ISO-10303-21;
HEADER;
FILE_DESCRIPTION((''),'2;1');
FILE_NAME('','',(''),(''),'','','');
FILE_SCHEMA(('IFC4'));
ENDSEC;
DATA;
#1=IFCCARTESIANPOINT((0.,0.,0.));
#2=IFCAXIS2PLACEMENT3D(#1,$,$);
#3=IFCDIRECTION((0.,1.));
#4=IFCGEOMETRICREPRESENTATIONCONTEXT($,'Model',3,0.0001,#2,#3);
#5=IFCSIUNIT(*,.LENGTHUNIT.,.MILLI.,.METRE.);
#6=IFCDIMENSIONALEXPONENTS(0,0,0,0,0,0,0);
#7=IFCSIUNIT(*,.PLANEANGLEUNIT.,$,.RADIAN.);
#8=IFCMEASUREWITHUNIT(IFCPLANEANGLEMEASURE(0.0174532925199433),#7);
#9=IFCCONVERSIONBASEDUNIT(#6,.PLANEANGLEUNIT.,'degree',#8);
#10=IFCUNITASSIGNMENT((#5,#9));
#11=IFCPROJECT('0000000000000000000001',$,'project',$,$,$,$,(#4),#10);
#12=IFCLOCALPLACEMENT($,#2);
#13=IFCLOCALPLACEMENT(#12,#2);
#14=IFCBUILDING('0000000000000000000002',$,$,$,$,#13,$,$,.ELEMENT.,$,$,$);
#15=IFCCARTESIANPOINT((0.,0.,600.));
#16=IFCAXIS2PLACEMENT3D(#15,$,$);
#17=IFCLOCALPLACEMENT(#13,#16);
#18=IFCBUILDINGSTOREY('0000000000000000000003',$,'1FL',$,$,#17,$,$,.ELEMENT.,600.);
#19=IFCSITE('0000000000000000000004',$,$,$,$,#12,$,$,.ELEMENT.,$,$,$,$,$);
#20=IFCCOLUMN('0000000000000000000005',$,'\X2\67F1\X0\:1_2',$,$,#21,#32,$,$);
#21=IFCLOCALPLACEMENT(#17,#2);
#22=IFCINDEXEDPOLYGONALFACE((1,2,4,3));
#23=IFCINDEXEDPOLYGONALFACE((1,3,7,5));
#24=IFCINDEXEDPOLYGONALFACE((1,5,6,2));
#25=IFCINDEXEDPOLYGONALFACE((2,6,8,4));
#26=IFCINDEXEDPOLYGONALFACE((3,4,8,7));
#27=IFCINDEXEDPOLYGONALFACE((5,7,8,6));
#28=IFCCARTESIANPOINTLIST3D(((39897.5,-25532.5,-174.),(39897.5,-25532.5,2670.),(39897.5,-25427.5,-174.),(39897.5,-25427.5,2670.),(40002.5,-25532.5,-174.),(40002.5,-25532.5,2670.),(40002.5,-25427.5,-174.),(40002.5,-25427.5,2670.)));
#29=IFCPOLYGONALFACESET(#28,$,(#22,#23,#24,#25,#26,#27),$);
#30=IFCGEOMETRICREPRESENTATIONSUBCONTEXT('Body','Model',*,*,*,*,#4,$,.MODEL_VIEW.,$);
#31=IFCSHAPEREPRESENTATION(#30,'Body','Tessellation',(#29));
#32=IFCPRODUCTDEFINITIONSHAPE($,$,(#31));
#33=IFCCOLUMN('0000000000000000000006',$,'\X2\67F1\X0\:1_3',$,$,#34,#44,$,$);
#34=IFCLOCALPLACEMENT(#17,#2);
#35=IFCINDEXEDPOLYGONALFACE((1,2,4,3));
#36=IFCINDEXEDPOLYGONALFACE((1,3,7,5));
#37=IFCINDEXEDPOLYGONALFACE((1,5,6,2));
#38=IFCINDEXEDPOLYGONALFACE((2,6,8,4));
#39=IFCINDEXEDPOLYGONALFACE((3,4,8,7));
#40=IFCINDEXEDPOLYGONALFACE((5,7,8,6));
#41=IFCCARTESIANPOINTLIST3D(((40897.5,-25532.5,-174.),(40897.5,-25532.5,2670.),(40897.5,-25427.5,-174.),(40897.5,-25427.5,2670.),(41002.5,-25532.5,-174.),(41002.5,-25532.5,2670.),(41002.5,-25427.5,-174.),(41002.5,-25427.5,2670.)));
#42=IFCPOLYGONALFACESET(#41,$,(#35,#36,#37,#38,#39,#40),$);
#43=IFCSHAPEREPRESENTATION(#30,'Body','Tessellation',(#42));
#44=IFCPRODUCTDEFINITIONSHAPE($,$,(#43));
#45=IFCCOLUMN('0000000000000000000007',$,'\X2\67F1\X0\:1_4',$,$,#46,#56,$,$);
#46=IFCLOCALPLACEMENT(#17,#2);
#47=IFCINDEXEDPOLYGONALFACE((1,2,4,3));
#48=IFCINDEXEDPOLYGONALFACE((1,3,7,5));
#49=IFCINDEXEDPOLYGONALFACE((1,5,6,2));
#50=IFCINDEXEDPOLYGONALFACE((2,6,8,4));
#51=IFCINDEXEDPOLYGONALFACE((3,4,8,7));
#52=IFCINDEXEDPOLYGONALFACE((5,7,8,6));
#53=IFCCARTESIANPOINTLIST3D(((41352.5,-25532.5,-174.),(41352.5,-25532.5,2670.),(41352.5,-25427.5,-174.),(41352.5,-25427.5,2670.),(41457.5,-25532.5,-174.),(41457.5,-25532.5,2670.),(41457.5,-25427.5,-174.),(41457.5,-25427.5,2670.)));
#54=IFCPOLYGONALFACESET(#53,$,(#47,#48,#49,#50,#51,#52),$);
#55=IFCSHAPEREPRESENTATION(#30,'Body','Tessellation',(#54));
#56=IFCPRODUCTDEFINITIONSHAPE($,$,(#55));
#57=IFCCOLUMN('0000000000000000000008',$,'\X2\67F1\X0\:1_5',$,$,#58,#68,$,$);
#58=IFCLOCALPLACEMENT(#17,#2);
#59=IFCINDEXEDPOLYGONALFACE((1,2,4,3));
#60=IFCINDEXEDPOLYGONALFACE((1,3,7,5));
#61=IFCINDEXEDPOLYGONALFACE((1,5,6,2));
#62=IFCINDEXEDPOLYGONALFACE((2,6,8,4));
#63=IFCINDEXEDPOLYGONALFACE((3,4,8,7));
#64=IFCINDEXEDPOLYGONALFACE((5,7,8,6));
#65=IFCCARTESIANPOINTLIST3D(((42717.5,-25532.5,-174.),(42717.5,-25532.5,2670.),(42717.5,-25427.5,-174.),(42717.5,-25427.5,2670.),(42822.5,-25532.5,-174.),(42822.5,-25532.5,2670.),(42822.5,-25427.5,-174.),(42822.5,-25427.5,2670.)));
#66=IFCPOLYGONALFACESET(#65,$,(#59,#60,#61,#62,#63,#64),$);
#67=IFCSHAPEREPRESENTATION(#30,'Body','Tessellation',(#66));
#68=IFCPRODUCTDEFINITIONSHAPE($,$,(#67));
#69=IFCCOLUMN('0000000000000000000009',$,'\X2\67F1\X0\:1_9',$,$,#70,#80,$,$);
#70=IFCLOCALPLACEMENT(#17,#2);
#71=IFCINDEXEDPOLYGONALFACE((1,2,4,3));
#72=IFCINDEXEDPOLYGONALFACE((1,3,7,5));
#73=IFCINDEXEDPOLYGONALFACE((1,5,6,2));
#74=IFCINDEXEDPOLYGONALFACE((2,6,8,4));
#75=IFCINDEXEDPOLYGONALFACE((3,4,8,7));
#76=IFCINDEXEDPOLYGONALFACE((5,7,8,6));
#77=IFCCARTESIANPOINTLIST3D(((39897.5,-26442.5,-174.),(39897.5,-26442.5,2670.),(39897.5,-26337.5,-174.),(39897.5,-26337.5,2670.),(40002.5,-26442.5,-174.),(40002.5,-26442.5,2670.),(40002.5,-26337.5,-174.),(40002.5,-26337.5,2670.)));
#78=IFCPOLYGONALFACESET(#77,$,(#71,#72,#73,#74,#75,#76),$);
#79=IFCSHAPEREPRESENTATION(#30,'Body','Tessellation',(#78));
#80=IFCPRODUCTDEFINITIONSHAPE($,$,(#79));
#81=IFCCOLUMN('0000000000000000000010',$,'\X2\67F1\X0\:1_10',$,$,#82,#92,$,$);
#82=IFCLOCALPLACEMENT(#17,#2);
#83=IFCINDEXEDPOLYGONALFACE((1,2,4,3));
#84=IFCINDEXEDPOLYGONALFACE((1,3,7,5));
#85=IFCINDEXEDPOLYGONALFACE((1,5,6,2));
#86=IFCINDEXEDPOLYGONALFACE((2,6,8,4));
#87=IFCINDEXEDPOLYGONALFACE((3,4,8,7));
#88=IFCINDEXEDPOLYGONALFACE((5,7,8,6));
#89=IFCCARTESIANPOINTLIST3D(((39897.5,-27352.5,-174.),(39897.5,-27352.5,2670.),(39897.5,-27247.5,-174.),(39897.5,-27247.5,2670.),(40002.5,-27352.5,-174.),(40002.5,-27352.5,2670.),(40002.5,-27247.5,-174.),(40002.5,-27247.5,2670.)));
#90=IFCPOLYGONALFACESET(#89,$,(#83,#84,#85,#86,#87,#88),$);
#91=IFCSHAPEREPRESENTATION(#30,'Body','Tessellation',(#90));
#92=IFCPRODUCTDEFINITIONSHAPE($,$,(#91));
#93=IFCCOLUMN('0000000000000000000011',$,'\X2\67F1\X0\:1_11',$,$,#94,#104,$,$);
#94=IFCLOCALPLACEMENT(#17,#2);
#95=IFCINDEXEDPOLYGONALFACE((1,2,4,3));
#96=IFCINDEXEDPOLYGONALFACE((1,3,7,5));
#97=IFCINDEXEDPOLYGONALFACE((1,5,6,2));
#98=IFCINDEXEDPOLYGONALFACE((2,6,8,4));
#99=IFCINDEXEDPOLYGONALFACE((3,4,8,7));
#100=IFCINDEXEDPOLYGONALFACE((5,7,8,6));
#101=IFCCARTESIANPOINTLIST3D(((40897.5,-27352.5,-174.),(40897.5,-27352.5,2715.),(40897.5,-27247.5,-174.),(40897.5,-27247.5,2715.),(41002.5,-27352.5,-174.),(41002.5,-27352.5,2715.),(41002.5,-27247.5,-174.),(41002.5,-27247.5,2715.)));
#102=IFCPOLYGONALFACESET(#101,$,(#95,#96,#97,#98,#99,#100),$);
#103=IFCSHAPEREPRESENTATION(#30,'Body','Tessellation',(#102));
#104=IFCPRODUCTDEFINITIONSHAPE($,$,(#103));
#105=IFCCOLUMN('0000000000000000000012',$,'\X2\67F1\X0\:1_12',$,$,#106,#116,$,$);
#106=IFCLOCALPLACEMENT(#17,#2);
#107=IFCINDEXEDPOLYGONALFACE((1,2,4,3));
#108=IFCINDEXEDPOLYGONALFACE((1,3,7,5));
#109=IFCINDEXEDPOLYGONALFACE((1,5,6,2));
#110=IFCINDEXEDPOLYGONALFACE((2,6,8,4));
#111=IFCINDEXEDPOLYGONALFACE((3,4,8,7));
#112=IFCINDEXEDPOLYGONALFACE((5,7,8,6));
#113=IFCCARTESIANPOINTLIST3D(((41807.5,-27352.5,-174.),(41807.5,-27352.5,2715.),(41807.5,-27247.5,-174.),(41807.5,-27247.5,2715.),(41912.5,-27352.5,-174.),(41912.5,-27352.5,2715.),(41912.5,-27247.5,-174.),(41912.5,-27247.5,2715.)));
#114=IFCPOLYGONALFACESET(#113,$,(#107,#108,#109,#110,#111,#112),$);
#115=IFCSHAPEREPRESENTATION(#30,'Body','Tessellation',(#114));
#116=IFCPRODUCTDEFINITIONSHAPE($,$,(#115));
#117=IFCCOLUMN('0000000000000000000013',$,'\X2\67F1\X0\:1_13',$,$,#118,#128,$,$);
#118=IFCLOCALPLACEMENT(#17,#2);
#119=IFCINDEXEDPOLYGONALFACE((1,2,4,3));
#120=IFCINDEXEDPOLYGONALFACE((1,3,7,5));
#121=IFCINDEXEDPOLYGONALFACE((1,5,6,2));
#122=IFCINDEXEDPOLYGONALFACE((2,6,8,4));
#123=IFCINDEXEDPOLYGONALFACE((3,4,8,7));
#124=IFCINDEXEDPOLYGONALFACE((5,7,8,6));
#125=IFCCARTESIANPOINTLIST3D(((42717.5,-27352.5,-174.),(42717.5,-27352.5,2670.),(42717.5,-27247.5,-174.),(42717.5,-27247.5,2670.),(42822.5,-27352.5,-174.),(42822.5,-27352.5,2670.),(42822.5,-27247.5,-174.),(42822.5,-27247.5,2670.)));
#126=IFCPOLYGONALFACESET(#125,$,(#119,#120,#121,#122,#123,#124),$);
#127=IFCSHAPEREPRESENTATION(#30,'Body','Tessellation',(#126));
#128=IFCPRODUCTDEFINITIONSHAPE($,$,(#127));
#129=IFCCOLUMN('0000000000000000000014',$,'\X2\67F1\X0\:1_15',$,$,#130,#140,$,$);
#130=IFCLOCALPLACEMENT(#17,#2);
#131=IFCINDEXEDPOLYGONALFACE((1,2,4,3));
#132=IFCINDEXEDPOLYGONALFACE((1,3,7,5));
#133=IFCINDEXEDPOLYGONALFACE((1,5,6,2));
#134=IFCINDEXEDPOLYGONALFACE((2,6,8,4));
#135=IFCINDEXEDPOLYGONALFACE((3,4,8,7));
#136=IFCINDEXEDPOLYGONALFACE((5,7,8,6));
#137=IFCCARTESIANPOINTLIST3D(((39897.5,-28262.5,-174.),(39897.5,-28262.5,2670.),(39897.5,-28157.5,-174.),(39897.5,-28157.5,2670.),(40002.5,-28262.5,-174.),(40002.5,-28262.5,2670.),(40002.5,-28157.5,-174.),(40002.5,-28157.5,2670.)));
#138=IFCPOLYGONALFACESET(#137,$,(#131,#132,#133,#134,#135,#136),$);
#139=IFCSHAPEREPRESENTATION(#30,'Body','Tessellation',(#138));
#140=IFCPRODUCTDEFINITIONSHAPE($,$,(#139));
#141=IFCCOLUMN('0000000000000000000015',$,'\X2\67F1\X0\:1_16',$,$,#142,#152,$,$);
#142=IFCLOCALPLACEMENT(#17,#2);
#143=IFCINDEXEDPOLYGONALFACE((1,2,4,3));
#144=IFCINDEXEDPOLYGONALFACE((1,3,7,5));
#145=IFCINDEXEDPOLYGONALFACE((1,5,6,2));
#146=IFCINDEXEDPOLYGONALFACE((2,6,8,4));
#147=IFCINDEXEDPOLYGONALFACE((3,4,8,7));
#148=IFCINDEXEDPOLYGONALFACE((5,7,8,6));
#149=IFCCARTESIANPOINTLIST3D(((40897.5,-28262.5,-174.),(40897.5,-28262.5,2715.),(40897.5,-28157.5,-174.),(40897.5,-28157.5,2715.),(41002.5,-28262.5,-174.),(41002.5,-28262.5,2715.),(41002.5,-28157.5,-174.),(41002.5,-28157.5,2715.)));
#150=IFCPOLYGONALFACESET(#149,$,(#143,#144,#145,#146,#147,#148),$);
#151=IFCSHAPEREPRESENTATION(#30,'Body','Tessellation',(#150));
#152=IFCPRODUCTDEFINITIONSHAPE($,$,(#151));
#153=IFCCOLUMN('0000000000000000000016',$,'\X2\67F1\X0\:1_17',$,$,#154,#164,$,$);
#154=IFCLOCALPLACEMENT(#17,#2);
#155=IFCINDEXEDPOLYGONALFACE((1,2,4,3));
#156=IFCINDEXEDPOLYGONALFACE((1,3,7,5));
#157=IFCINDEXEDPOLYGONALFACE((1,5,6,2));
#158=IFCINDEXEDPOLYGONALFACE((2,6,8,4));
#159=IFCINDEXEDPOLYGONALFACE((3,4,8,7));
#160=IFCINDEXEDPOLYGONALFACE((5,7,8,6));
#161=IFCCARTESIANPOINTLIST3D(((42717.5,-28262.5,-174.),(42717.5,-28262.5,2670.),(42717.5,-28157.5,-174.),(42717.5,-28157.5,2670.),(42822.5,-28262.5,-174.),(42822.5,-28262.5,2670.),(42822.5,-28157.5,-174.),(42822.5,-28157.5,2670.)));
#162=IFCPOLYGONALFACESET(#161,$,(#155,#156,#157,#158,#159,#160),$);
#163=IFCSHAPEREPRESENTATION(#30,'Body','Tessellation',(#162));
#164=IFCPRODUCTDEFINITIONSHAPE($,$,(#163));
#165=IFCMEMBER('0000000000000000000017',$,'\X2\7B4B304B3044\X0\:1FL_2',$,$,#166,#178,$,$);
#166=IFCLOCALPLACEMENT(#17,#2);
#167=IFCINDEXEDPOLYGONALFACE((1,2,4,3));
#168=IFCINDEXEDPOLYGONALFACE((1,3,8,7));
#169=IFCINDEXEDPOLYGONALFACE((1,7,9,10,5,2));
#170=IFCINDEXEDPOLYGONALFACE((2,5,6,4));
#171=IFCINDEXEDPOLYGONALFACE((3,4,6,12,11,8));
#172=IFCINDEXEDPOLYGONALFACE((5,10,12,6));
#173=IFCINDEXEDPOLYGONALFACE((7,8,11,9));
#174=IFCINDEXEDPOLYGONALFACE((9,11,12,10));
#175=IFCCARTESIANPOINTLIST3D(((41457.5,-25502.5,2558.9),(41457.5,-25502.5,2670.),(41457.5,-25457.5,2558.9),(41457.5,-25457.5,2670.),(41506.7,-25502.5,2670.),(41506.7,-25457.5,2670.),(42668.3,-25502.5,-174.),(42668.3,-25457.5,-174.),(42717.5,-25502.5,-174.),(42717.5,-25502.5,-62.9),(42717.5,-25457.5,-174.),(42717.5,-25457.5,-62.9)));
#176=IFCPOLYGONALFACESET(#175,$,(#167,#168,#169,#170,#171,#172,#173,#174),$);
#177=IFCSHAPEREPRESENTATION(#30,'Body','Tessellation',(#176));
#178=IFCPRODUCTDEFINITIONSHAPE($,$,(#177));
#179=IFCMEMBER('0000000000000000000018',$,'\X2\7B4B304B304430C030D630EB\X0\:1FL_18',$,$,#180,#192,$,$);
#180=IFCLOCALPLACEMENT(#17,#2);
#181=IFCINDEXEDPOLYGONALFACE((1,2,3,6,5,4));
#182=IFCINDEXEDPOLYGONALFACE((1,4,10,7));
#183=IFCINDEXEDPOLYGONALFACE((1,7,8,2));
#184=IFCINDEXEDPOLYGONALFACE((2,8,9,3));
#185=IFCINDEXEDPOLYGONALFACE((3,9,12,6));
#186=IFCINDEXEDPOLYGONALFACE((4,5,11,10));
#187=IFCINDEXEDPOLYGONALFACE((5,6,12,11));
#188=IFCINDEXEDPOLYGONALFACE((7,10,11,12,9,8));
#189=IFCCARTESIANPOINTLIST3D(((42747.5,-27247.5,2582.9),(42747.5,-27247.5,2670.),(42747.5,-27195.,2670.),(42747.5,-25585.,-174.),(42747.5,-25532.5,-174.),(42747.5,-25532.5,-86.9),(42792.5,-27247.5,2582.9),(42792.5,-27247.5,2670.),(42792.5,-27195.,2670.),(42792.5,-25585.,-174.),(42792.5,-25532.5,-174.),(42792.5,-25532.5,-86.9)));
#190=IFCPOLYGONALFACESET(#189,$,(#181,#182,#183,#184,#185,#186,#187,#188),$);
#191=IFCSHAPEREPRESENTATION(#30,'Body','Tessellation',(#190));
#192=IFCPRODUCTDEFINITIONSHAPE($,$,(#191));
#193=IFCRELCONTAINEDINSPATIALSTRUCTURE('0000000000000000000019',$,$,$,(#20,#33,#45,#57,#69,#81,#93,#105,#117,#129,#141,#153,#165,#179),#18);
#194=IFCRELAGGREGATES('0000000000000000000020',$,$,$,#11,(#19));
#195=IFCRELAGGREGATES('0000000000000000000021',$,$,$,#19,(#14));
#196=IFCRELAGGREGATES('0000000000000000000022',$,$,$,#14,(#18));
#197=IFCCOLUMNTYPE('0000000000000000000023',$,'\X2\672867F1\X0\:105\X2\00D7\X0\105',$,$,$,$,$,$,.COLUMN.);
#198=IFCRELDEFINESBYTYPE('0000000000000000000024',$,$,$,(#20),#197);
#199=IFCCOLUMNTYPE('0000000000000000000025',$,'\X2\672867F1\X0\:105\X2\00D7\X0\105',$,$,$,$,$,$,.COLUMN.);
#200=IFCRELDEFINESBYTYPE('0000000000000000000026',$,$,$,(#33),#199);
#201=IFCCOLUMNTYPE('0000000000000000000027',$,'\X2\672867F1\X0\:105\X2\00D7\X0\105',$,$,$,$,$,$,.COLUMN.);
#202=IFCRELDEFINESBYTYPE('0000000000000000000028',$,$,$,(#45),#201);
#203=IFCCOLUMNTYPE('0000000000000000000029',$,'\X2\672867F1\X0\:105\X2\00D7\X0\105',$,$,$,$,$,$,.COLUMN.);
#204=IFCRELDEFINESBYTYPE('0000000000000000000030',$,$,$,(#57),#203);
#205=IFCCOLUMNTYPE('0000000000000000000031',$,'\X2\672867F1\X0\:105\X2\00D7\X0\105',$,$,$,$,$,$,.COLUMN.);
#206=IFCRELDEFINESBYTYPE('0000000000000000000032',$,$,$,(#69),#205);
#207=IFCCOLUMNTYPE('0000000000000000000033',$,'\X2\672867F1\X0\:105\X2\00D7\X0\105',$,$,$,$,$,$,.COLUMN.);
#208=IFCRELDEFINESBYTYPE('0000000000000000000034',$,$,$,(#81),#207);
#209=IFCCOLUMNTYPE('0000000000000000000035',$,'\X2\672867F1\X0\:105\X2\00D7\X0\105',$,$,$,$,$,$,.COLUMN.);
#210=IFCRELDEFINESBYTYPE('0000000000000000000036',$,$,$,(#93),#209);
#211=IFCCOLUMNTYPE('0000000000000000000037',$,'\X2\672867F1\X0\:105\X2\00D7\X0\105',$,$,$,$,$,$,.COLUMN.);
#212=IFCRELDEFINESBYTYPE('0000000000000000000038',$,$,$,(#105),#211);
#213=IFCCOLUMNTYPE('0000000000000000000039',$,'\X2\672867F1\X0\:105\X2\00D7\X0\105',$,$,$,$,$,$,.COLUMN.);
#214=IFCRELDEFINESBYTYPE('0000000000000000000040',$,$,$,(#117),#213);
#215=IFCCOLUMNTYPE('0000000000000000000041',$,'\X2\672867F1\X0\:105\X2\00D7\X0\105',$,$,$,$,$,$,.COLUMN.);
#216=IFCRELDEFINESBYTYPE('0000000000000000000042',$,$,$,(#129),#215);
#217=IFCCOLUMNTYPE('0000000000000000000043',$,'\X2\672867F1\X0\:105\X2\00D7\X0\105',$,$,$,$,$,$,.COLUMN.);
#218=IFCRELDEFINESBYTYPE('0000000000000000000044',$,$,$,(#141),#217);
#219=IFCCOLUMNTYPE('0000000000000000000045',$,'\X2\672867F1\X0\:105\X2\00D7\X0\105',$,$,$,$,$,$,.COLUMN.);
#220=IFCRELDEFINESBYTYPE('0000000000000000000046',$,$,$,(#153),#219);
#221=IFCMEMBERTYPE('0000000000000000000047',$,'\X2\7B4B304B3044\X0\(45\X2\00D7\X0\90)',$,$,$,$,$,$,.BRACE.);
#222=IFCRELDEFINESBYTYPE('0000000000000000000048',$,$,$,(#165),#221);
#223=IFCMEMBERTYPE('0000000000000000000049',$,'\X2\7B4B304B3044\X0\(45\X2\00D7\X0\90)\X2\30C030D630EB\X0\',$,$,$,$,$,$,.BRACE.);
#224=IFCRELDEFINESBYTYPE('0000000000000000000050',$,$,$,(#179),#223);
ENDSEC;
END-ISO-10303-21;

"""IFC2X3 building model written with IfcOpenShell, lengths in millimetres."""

from ifc_helpers import new_model, entity, si_unit, converted_unit, direction, frame, origin, origin_with_axes, origin_2d, place, context, subcontext, project, spatial, polyline, rectangle, outline, extrude, type_object, element, save


model = new_model("IFC2X3")

# Units and contexts
model_context = context("Model", 3, precision=0.0001, world=origin(), true_north=direction((0.0, 1.0)))
body_context = subcontext(model_context, "Body", "Model", "MODEL_VIEW")
ifc_project = project(units=[si_unit("LENGTHUNIT", "METRE", prefix="MILLI"), converted_unit("PLANEANGLEUNIT", "degree", entity("IfcPlaneAngleMeasure", 0.0174532925199433), si_unit("PLANEANGLEUNIT", "RADIAN"), dimensions=[0, 0, 0, 0, 0, 0, 0])], contexts=[model_context])

# Site, building, storey
site_placement = place(None, origin())
site = spatial("IfcSite", under=ifc_project, at=site_placement, CompositionType="ELEMENT")
building_placement = place(site_placement, origin())
building = spatial("IfcBuilding", under=site, at=building_placement, CompositionType="ELEMENT")
storey_placement = place(building_placement, frame((0.0, 0.0, 600.0)))
storey = spatial("IfcBuildingStorey", under=building, at=storey_placement, Name="1FL", CompositionType="ELEMENT", Elevation=600.0)

# Columns
column_type_1 = type_object("IfcColumnType", Name="木柱:105×105", PredefinedType="COLUMN")
column_1_placement = place(storey_placement, frame((39950.0, -25480.0, -174.0)))
element("IfcColumn", 1, at=column_1_placement, inside=storey, type_object=column_type_1, Name="柱:1_2", context=body_context, shape_type="SweptSolid", body=[
    extrude(rectangle(XDim=105.0, YDim=105.0, at=origin_2d()), origin_with_axes(), (0.0, 0.0, 1.0), 2844.0),
])
column_type_2 = type_object("IfcColumnType", Name="木柱:105×105", PredefinedType="COLUMN")
column_2_placement = place(storey_placement, frame((40950.0, -25480.0, -174.0)))
element("IfcColumn", 2, at=column_2_placement, inside=storey, type_object=column_type_2, Name="柱:1_3", context=body_context, shape_type="SweptSolid", body=[
    extrude(rectangle(XDim=105.0, YDim=105.0, at=origin_2d()), origin_with_axes(), (0.0, 0.0, 1.0), 2844.0),
])
column_type_3 = type_object("IfcColumnType", Name="木柱:105×105", PredefinedType="COLUMN")
column_3_placement = place(storey_placement, frame((41405.0, -25480.0, -174.0)))
element("IfcColumn", 3, at=column_3_placement, inside=storey, type_object=column_type_3, Name="柱:1_4", context=body_context, shape_type="SweptSolid", body=[
    extrude(rectangle(XDim=105.0, YDim=105.0, at=origin_2d()), origin_with_axes(), (0.0, 0.0, 1.0), 2844.0),
])
column_type_4 = type_object("IfcColumnType", Name="木柱:105×105", PredefinedType="COLUMN")
column_4_placement = place(storey_placement, frame((42770.0, -25480.0, -174.0)))
element("IfcColumn", 4, at=column_4_placement, inside=storey, type_object=column_type_4, Name="柱:1_5", context=body_context, shape_type="SweptSolid", body=[
    extrude(rectangle(XDim=105.0, YDim=105.0, at=origin_2d()), origin_with_axes(), (0.0, 0.0, 1.0), 2844.0),
])
column_type_5 = type_object("IfcColumnType", Name="木柱:105×105", PredefinedType="COLUMN")
column_5_placement = place(storey_placement, frame((39950.0, -26390.0, -174.0)))
element("IfcColumn", 5, at=column_5_placement, inside=storey, type_object=column_type_5, Name="柱:1_9", context=body_context, shape_type="SweptSolid", body=[
    extrude(rectangle(XDim=105.0, YDim=105.0, at=origin_2d()), origin_with_axes(), (0.0, 0.0, 1.0), 2844.0),
])
column_type_6 = type_object("IfcColumnType", Name="木柱:105×105", PredefinedType="COLUMN")
column_6_placement = place(storey_placement, frame((39950.0, -27300.0, -174.0)))
element("IfcColumn", 6, at=column_6_placement, inside=storey, type_object=column_type_6, Name="柱:1_10", context=body_context, shape_type="SweptSolid", body=[
    extrude(rectangle(XDim=105.0, YDim=105.0, at=origin_2d()), origin_with_axes(), (0.0, 0.0, 1.0), 2844.0),
])
column_type_7 = type_object("IfcColumnType", Name="木柱:105×105", PredefinedType="COLUMN")
column_7_placement = place(storey_placement, frame((40950.0, -27300.0, -174.0)))
element("IfcColumn", 7, at=column_7_placement, inside=storey, type_object=column_type_7, Name="柱:1_11", context=body_context, shape_type="SweptSolid", body=[
    extrude(rectangle(XDim=105.0, YDim=105.0, at=origin_2d()), origin_with_axes(), (0.0, 0.0, 1.0), 2889.0),
])
column_type_8 = type_object("IfcColumnType", Name="木柱:105×105", PredefinedType="COLUMN")
column_8_placement = place(storey_placement, frame((41860.0, -27300.0, -174.0)))
element("IfcColumn", 8, at=column_8_placement, inside=storey, type_object=column_type_8, Name="柱:1_12", context=body_context, shape_type="SweptSolid", body=[
    extrude(rectangle(XDim=105.0, YDim=105.0, at=origin_2d()), origin_with_axes(), (0.0, 0.0, 1.0), 2889.0),
])
column_type_9 = type_object("IfcColumnType", Name="木柱:105×105", PredefinedType="COLUMN")
column_9_placement = place(storey_placement, frame((42770.0, -27300.0, -174.0)))
element("IfcColumn", 9, at=column_9_placement, inside=storey, type_object=column_type_9, Name="柱:1_13", context=body_context, shape_type="SweptSolid", body=[
    extrude(rectangle(XDim=105.0, YDim=105.0, at=origin_2d()), origin_with_axes(), (0.0, 0.0, 1.0), 2844.0),
])
column_type_10 = type_object("IfcColumnType", Name="木柱:105×105", PredefinedType="COLUMN")
column_10_placement = place(storey_placement, frame((39950.0, -28210.0, -174.0)))
element("IfcColumn", 10, at=column_10_placement, inside=storey, type_object=column_type_10, Name="柱:1_15", context=body_context, shape_type="SweptSolid", body=[
    extrude(rectangle(XDim=105.0, YDim=105.0, at=origin_2d()), origin_with_axes(), (0.0, 0.0, 1.0), 2844.0),
])
column_type_11 = type_object("IfcColumnType", Name="木柱:105×105", PredefinedType="COLUMN")
column_11_placement = place(storey_placement, frame((40950.0, -28210.0, -174.0)))
element("IfcColumn", 11, at=column_11_placement, inside=storey, type_object=column_type_11, Name="柱:1_16", context=body_context, shape_type="SweptSolid", body=[
    extrude(rectangle(XDim=105.0, YDim=105.0, at=origin_2d()), origin_with_axes(), (0.0, 0.0, 1.0), 2889.0),
])
column_type_12 = type_object("IfcColumnType", Name="木柱:105×105", PredefinedType="COLUMN")
column_12_placement = place(storey_placement, frame((42770.0, -28210.0, -174.0)))
element("IfcColumn", 12, at=column_12_placement, inside=storey, type_object=column_type_12, Name="柱:1_17", context=body_context, shape_type="SweptSolid", body=[
    extrude(rectangle(XDim=105.0, YDim=105.0, at=origin_2d()), origin_with_axes(), (0.0, 0.0, 1.0), 2844.0),
])

# Members
member_type_1 = type_object("IfcMemberType", Name="筋かい(45×90)", PredefinedType="BRACE")
member_1_placement = place(storey_placement, frame((42717.5, -25480.0, -174.0), z_axis=(-0.405064, 0.0, 0.914288), x_axis=(0.914288, 0.0, 0.405064)))
element("IfcMember", 13, at=member_1_placement, inside=storey, type_object=member_type_1, Name="筋かい:1FL_2", context=body_context, shape_type="SweptSolid", body=[
    extrude(outline(polyline([(0.0, 0.0), (19.9, -45.0), (3009.0, -45.0), (3110.6, 0.0), (3090.7, 45.0), (101.6, 45.0), (0.0, 0.0)])), frame((0.0, -22.5, 0.0), z_axis=(0.0, 1.0, 0.0), x_axis=(0.0, 0.0, 1.0)), (0.0, 0.0, 1.0), 45.0),
])
member_type_2 = type_object("IfcMemberType", Name="筋かい(45×90)ダブル", PredefinedType="BRACE")
member_2_placement = place(storey_placement, frame((42770.0, -25532.5, -174.0), z_axis=(0.0, -0.516399, 0.856348), x_axis=(0.0, 0.856348, 0.516399)))
element("IfcMember", 14, at=member_2_placement, inside=storey, type_object=member_type_2, Name="筋かいダブル:1FL_18", context=body_context, shape_type="SweptSolid", body=[
    extrude(outline(polyline([(0.0, 0.0), (27.1, -45.0), (3246.5, -45.0), (3321.1, 0.0), (3293.9, 45.0), (74.6, 45.0), (0.0, 0.0)])), frame((0.0, -22.5, 0.0), z_axis=(0.0, 1.0, 0.0), x_axis=(0.0, 0.0, 1.0)), (0.0, 0.0, 1.0), 45.0),
])

save(model, "model.ifc")
